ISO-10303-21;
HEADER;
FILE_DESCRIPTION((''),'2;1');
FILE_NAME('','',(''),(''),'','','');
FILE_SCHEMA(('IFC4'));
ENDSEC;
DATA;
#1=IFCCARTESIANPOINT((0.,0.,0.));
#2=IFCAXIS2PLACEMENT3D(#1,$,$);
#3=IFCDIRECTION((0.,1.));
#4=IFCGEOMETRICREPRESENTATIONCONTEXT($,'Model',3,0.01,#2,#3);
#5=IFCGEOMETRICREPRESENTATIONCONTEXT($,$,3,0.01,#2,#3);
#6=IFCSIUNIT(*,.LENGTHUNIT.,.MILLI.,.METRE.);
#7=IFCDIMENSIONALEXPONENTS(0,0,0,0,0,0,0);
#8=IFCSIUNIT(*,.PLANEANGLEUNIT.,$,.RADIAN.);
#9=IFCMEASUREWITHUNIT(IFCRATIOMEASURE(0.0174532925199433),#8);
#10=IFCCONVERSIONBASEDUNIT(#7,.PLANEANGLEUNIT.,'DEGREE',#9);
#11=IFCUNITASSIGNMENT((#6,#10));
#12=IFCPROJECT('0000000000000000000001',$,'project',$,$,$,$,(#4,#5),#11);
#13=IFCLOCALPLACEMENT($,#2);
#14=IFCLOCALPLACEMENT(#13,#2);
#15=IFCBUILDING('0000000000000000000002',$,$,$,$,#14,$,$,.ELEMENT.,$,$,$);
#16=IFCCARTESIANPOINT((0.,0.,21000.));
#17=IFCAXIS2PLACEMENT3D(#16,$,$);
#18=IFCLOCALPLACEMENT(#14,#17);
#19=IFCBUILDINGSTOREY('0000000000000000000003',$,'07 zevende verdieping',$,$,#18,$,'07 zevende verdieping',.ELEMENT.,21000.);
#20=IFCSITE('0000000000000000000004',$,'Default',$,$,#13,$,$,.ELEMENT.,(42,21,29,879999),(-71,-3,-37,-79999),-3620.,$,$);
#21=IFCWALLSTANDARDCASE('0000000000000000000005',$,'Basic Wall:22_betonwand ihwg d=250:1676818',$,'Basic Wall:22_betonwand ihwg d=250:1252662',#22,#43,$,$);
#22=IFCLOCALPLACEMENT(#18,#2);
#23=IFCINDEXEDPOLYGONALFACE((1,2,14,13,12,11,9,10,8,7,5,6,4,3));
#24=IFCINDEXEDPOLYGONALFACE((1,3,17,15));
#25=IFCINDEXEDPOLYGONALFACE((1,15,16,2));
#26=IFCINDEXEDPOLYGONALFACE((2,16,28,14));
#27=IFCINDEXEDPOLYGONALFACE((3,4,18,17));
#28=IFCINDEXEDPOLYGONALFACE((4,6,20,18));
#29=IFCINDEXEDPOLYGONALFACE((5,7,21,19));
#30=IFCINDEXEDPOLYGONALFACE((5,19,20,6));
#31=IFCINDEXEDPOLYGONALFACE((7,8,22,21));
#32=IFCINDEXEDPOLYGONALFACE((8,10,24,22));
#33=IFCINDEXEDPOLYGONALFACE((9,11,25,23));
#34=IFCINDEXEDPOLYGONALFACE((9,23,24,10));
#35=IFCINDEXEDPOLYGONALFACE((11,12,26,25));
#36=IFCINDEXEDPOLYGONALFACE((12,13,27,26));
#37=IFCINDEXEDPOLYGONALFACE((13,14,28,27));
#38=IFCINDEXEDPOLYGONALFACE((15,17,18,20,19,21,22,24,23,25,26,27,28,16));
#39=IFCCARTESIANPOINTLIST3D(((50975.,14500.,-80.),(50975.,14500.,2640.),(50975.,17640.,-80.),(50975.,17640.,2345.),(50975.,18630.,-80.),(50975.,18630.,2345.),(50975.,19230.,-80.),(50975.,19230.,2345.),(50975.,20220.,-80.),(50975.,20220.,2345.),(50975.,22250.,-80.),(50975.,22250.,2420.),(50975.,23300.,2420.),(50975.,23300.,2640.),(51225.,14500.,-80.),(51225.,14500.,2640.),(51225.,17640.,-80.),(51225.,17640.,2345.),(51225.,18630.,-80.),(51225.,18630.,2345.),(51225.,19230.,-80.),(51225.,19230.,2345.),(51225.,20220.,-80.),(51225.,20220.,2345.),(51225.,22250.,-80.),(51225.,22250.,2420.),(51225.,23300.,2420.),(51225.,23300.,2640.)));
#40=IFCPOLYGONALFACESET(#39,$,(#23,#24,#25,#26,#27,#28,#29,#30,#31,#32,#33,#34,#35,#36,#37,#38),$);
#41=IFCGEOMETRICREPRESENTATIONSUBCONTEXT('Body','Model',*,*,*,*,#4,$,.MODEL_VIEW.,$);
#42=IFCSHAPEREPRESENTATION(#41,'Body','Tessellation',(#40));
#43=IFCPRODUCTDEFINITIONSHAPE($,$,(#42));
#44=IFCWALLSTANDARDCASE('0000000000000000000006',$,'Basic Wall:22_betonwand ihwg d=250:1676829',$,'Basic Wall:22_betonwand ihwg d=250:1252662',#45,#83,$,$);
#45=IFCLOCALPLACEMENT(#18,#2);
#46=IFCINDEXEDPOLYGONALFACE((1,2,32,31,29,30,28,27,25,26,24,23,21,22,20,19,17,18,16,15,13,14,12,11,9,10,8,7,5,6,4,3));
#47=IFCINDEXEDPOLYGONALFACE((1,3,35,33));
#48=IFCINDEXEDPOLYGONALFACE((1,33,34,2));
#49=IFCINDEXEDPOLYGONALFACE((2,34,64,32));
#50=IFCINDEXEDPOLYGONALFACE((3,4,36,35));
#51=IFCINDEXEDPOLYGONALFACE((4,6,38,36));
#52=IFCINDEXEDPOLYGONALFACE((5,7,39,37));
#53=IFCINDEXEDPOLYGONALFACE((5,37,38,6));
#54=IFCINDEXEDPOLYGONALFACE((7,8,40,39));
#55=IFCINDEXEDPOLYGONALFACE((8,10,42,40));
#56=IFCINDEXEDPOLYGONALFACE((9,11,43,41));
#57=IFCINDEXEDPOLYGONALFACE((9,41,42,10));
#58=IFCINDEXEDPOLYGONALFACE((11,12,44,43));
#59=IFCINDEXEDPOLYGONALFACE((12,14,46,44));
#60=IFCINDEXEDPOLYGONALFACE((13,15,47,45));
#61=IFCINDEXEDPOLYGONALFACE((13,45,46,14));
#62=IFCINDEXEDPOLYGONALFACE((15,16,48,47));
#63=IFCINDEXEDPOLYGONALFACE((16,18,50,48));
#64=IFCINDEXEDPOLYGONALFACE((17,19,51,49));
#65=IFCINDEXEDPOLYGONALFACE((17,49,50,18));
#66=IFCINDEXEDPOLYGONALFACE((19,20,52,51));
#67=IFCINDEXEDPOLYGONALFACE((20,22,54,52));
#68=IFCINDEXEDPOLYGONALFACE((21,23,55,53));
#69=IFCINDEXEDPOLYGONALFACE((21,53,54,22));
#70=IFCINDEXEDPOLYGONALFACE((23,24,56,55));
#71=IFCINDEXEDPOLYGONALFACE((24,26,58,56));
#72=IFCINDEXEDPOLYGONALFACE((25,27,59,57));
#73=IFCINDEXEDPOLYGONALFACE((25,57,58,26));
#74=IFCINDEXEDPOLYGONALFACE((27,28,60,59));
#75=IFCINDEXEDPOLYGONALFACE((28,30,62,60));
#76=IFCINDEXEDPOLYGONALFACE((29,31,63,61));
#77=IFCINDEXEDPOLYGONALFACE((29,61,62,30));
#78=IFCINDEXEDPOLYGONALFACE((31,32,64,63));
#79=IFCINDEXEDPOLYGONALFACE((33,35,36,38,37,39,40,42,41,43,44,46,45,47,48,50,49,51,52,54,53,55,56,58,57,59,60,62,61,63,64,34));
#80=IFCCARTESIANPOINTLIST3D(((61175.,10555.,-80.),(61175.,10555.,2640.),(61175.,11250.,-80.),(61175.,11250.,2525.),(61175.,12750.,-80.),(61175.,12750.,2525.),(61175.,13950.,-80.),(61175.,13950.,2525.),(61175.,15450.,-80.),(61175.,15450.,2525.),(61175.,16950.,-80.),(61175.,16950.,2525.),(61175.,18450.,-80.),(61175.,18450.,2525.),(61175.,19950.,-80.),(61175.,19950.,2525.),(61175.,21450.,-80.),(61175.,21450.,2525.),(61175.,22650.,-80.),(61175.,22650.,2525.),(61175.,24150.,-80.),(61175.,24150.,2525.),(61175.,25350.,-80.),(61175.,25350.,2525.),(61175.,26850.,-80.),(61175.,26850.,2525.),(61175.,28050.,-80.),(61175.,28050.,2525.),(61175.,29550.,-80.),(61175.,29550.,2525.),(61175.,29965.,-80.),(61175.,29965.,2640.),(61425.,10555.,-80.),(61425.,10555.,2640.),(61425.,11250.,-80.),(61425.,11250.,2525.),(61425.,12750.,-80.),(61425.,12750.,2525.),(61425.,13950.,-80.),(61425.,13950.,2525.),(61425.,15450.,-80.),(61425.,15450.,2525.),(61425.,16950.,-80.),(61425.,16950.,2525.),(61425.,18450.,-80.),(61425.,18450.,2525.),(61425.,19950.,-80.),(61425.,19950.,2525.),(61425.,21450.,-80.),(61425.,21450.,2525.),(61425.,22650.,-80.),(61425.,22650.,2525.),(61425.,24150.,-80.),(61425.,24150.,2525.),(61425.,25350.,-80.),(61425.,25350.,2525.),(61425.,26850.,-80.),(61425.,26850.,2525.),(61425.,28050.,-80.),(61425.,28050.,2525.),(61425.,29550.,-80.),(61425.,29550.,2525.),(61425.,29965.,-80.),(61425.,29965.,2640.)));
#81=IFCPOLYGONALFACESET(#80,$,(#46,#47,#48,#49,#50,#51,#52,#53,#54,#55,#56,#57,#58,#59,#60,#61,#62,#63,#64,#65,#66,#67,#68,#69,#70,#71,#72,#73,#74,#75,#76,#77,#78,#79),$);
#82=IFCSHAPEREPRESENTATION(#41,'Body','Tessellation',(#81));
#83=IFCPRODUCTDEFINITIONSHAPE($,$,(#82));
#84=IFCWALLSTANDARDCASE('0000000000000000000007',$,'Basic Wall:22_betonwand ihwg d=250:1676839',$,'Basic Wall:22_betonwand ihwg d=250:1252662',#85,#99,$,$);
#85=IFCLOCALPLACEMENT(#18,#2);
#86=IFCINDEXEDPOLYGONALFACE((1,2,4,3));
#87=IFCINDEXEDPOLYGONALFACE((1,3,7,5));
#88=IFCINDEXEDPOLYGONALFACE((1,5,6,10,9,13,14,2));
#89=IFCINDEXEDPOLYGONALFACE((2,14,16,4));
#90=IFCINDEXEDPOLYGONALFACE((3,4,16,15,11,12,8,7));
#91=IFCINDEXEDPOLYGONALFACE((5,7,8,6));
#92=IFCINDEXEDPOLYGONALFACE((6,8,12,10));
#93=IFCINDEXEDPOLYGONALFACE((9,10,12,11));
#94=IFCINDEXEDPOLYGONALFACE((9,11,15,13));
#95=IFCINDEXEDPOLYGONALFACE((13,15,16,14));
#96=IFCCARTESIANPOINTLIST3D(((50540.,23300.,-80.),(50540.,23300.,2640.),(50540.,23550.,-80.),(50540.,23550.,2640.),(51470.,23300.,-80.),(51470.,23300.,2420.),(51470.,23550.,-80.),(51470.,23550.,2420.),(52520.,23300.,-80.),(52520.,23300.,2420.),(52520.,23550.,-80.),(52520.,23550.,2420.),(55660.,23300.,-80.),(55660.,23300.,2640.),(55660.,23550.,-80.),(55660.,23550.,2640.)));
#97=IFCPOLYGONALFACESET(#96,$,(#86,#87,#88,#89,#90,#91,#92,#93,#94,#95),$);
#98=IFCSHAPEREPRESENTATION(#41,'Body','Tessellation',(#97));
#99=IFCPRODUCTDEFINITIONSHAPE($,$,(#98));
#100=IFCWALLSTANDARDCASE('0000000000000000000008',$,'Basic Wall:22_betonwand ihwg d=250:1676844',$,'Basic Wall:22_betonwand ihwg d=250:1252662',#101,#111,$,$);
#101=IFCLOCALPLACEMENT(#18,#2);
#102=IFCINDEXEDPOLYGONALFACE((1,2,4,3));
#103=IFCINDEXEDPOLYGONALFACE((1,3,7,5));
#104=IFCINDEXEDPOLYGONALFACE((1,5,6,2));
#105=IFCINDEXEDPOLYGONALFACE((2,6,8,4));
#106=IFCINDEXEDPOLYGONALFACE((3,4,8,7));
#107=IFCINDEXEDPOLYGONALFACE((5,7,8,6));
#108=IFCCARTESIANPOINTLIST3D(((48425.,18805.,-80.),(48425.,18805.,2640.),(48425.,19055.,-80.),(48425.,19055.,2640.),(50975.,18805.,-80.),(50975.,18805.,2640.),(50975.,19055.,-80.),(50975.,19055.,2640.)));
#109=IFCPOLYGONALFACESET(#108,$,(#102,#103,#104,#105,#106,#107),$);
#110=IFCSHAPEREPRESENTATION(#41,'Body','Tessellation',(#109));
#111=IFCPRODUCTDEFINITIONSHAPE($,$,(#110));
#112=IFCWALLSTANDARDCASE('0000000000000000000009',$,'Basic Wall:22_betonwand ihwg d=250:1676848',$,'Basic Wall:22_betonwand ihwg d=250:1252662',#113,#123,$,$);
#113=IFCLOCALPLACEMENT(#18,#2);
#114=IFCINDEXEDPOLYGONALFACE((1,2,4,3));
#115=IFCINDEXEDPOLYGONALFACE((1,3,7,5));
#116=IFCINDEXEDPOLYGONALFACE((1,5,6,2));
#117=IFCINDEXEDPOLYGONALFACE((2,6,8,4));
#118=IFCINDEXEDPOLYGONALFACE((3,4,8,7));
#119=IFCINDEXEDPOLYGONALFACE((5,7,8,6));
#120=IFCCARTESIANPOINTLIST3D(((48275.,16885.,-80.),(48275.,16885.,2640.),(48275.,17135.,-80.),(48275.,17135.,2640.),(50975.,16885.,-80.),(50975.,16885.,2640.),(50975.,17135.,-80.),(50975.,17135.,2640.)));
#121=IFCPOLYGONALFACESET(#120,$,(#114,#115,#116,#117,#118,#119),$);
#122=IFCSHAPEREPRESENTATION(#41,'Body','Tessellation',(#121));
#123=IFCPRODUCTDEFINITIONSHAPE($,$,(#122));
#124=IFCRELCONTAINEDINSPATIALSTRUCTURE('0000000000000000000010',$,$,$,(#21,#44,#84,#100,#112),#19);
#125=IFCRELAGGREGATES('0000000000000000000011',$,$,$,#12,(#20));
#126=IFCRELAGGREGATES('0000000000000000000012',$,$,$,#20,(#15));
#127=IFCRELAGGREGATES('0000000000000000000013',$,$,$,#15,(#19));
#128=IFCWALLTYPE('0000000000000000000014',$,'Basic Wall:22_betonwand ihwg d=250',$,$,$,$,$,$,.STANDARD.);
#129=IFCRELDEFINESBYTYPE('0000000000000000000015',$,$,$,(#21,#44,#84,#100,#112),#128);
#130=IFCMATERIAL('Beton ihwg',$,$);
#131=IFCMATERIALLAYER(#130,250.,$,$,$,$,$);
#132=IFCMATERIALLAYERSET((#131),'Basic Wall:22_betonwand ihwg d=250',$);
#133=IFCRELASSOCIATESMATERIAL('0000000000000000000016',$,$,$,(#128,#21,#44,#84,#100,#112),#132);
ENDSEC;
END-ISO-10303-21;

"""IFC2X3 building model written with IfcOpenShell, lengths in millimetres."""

from ifc_helpers import new_model, entity, si_unit, converted_unit, direction, frame, frame_2d, origin, place, context, subcontext, project, spatial, rectangle, extrude, material, layer, layer_set, layer_usage, type_object, element, save


model = new_model("IFC2X3")

# Units and contexts
model_context = context("Model", 3, precision=0.01, world=origin(), true_north=direction((0.0, 1.0)))
context_of_model = context(None, 3, precision=0.01, world=origin(), true_north=direction((0.0, 1.0)))
body_context = subcontext(model_context, "Body", "Model", "MODEL_VIEW")
ifc_project = project(units=[si_unit("LENGTHUNIT", "METRE", prefix="MILLI"), converted_unit("PLANEANGLEUNIT", "DEGREE", entity("IfcRatioMeasure", 0.0174532925199433), si_unit("PLANEANGLEUNIT", "RADIAN"), dimensions=[0, 0, 0, 0, 0, 0, 0])], contexts=[model_context, context_of_model])

# Site, building, storey
site_placement = place(None, origin())
site = spatial("IfcSite", under=ifc_project, at=site_placement, Name="Default", CompositionType="ELEMENT", RefLatitude=(42, 21, 29, 879999), RefLongitude=(-71, -3, -37, -79999), RefElevation=-3620.0)
building_placement = place(site_placement, origin())
building = spatial("IfcBuilding", under=site, at=building_placement, CompositionType="ELEMENT")
storey_placement = place(building_placement, frame((0.0, 0.0, 21000.0)))
storey = spatial("IfcBuildingStorey", under=building, at=storey_placement, Name="07 zevende verdieping", LongName="07 zevende verdieping", CompositionType="ELEMENT", Elevation=21000.0)

# Walls, openings
ifc_material_1 = material(Name="Beton ihwg")
ifc_layer_1 = layer(ifc_material_1, 250.0)
ifc_layer_set_1 = layer_set([ifc_layer_1], Name="Basic Wall:22_betonwand ihwg d=250")
ifc_layer_usage_1 = layer_usage(ifc_layer_set_1, "AXIS2", "NEGATIVE", 125.0)
wall_type_1 = type_object("IfcWallType", Name="Basic Wall:22_betonwand ihwg d=250", PredefinedType="STANDARD", material=ifc_layer_set_1)
wall_1_placement = place(storey_placement, frame((51100.0, 23300.0, -80.0), z_axis=(0.0, 0.0, 1.0), x_axis=(0.0, -1.0, 0.0)))
wall_1 = element("IfcWallStandardCase", 1, at=wall_1_placement, inside=storey, type_object=wall_type_1, material=ifc_layer_usage_1, Name="Basic Wall:22_betonwand ihwg d=250:1676818", ObjectType="Basic Wall:22_betonwand ihwg d=250:1252662", context=body_context, shape_type="SweptSolid", body=[
    extrude(rectangle(XDim=8800.0, YDim=250.0, at=frame_2d((4400.0, 0.0), x_axis=(-1.0, 0.0))), origin(), (0.0, 0.0, 1.0), 2720.0),
])
opening_1_placement = place(wall_1_placement, frame((23300.0, -51100.0, 80.0), z_axis=(0.0, 0.0, 1.0), x_axis=(0.0, 1.0, 0.0)))
element("IfcOpeningElement", 2, at=opening_1_placement, cuts=wall_1, ObjectType="Opening", context=body_context, shape_type="SweptSolid", body=[
    extrude(rectangle(XDim=2425.0, YDim=990.0, at=frame_2d((0.0, 0.0), x_axis=(1.0, 0.0))), frame((50700.0, 19725.0, 1132.5), z_axis=(1.0, 0.0, 0.0), x_axis=(0.0, 0.0, -1.0)), (0.0, 0.0, 1.0), 800.0),
])
opening_2_placement = place(wall_1_placement, frame((23300.0, -51100.0, 80.0), z_axis=(0.0, 0.0, 1.0), x_axis=(0.0, 1.0, 0.0)))
element("IfcOpeningElement", 3, at=opening_2_placement, cuts=wall_1, ObjectType="Opening", context=body_context, shape_type="SweptSolid", body=[
    extrude(rectangle(XDim=2425.0, YDim=990.0, at=frame_2d((0.0, 0.0), x_axis=(1.0, 0.0))), frame((50700.0, 18135.0, 1132.5), z_axis=(1.0, 0.0, 0.0), x_axis=(0.0, 0.0, -1.0)), (0.0, 0.0, 1.0), 800.0),
])
opening_3_placement = place(wall_1_placement, frame((23300.0, -51100.0, 80.0), z_axis=(0.0, 0.0, 1.0), x_axis=(0.0, 1.0, 0.0)))
element("IfcOpeningElement", 4, at=opening_3_placement, cuts=wall_1, ObjectType="Opening", context=body_context, shape_type="SweptSolid", body=[
    extrude(rectangle(XDim=2500.0, YDim=1050.0, at=frame_2d((0.0, 0.0), x_axis=(1.0, 0.0))), frame((50700.0, 22775.0, 1170.0), z_axis=(1.0, 0.0, 0.0), x_axis=(0.0, 0.0, -1.0)), (0.0, 0.0, 1.0), 800.0),
])
ifc_layer_usage_2 = layer_usage(ifc_layer_set_1, "AXIS2", "POSITIVE", -125.0)
wall_2_placement = place(storey_placement, frame((61300.0, 29965.0, -80.0), z_axis=(0.0, 0.0, 1.0), x_axis=(0.0, -1.0, 0.0)))
wall_2 = element("IfcWallStandardCase", 5, at=wall_2_placement, inside=storey, type_object=wall_type_1, material=ifc_layer_usage_2, Name="Basic Wall:22_betonwand ihwg d=250:1676829", ObjectType="Basic Wall:22_betonwand ihwg d=250:1252662", context=body_context, shape_type="SweptSolid", body=[
    extrude(rectangle(XDim=19410.0, YDim=250.0, at=frame_2d((9705.0, 0.0), x_axis=(-1.0, 0.0))), origin(), (0.0, 0.0, 1.0), 2720.0),
])
opening_4_placement = place(wall_2_placement, frame((29965.0, -61300.0, 80.0), z_axis=(0.0, 0.0, 1.0), x_axis=(0.0, 1.0, 0.0)))
element("IfcOpeningElement", 6, at=opening_4_placement, cuts=wall_2, ObjectType="Opening", context=body_context, shape_type="SweptSolid", body=[
    extrude(rectangle(XDim=2605.0, YDim=1500.0, at=frame_2d((0.0, 0.0), x_axis=(1.0, 0.0))), frame((59901.0, 28800.0, 1222.5), z_axis=(1.0, 0.0, 0.0), x_axis=(0.0, 0.0, -1.0)), (0.0, 0.0, 1.0), 3048.0),
])
opening_5_placement = place(wall_2_placement, frame((29965.0, -61300.0, 80.0), z_axis=(0.0, 0.0, 1.0), x_axis=(0.0, 1.0, 0.0)))
element("IfcOpeningElement", 7, at=opening_5_placement, cuts=wall_2, ObjectType="Opening", context=body_context, shape_type="SweptSolid", body=[
    extrude(rectangle(XDim=2605.0, YDim=1500.0, at=frame_2d((0.0, 0.0), x_axis=(1.0, 0.0))), frame((59901.0, 26100.0, 1222.5), z_axis=(1.0, 0.0, 0.0), x_axis=(0.0, 0.0, -1.0)), (0.0, 0.0, 1.0), 3048.0),
])
opening_6_placement = place(wall_2_placement, frame((29965.0, -61300.0, 80.0), z_axis=(0.0, 0.0, 1.0), x_axis=(0.0, 1.0, 0.0)))
element("IfcOpeningElement", 8, at=opening_6_placement, cuts=wall_2, ObjectType="Opening", context=body_context, shape_type="SweptSolid", body=[
    extrude(rectangle(XDim=2605.0, YDim=1500.0, at=frame_2d((0.0, 0.0), x_axis=(1.0, 0.0))), frame((59901.0, 23400.0, 1222.5), z_axis=(1.0, 0.0, 0.0), x_axis=(0.0, 0.0, -1.0)), (0.0, 0.0, 1.0), 3048.0),
])
opening_7_placement = place(wall_2_placement, frame((29965.0, -61300.0, 80.0), z_axis=(0.0, 0.0, 1.0), x_axis=(0.0, 1.0, 0.0)))
element("IfcOpeningElement", 9, at=opening_7_placement, cuts=wall_2, ObjectType="Opening", context=body_context, shape_type="SweptSolid", body=[
    extrude(rectangle(XDim=2605.0, YDim=1500.0, at=frame_2d((0.0, 0.0), x_axis=(1.0, 0.0))), frame((59901.0, 17700.0, 1222.5), z_axis=(1.0, 0.0, 0.0), x_axis=(0.0, 0.0, -1.0)), (0.0, 0.0, 1.0), 3048.0),
])
opening_8_placement = place(wall_2_placement, frame((29965.0, -61300.0, 80.0), z_axis=(0.0, 0.0, 1.0), x_axis=(0.0, 1.0, 0.0)))
element("IfcOpeningElement", 10, at=opening_8_placement, cuts=wall_2, ObjectType="Opening", context=body_context, shape_type="SweptSolid", body=[
    extrude(rectangle(XDim=2605.0, YDim=1500.0, at=frame_2d((0.0, 0.0), x_axis=(1.0, 0.0))), frame((59901.0, 14700.0, 1222.5), z_axis=(1.0, 0.0, 0.0), x_axis=(0.0, 0.0, -1.0)), (0.0, 0.0, 1.0), 3048.0),
])
opening_9_placement = place(wall_2_placement, frame((29965.0, -61300.0, 80.0), z_axis=(0.0, 0.0, 1.0), x_axis=(0.0, 1.0, 0.0)))
element("IfcOpeningElement", 11, at=opening_9_placement, cuts=wall_2, ObjectType="Opening", context=body_context, shape_type="SweptSolid", body=[
    extrude(rectangle(XDim=2605.0, YDim=1500.0, at=frame_2d((0.0, 0.0), x_axis=(1.0, 0.0))), frame((59901.0, 20700.0, 1222.5), z_axis=(1.0, 0.0, 0.0), x_axis=(0.0, 0.0, -1.0)), (0.0, 0.0, 1.0), 3048.0),
])
opening_10_placement = place(wall_2_placement, frame((29965.0, -61300.0, 80.0), z_axis=(0.0, 0.0, 1.0), x_axis=(0.0, 1.0, 0.0)))
element("IfcOpeningElement", 12, at=opening_10_placement, cuts=wall_2, ObjectType="Opening", context=body_context, shape_type="SweptSolid", body=[
    extrude(rectangle(XDim=2605.0, YDim=1500.0, at=frame_2d((0.0, 0.0), x_axis=(1.0, 0.0))), frame((59901.0, 12000.0, 1222.5), z_axis=(1.0, 0.0, 0.0), x_axis=(0.0, 0.0, -1.0)), (0.0, 0.0, 1.0), 3048.0),
])
ifc_layer_usage_3 = layer_usage(ifc_layer_set_1, "AXIS2", "POSITIVE", -125.0)
wall_3_placement = place(storey_placement, frame((55660.0, 23425.0, -80.0), z_axis=(0.0, 0.0, 1.0), x_axis=(-1.0, 0.0, 0.0)))
wall_3 = element("IfcWallStandardCase", 13, at=wall_3_placement, inside=storey, type_object=wall_type_1, material=ifc_layer_usage_3, Name="Basic Wall:22_betonwand ihwg d=250:1676839", ObjectType="Basic Wall:22_betonwand ihwg d=250:1252662", context=body_context, shape_type="SweptSolid", body=[
    extrude(rectangle(XDim=5120.0, YDim=250.0, at=frame_2d((2560.0, 0.0), x_axis=(-1.0, 0.0))), origin(), (0.0, 0.0, 1.0), 2720.0),
])
opening_11_placement = place(wall_3_placement, origin())
element("IfcOpeningElement", 14, at=opening_11_placement, cuts=wall_3, ObjectType="Opening", context=body_context, shape_type="SweptSolid", body=[
    extrude(rectangle(XDim=2500.0, YDim=800.0, at=frame_2d((0.0, 0.0), x_axis=(0.0, 1.0))), frame((4560.0, 125.0, 1250.0), z_axis=(0.0, 1.0, 0.0), x_axis=(1.0, 0.0, 0.0)), (0.0, 0.0, 1.0), 1050.0),
])
opening_12_placement = place(wall_3_placement, origin())
element("IfcOpeningElement", 15, at=opening_12_placement, cuts=wall_3, ObjectType="Opening", context=body_context, shape_type="SweptSolid", body=[
    extrude(rectangle(XDim=2500.0, YDim=800.0, at=frame_2d((0.0, 0.0), x_axis=(0.0, 1.0))), frame((2735.0, 125.0, 1250.0), z_axis=(0.0, 1.0, 0.0), x_axis=(1.0, 0.0, 0.0)), (0.0, 0.0, 1.0), 1034.0),
])
opening_13_placement = place(wall_3_placement, frame((55660.0, 23425.0, 80.0), z_axis=(0.0, 0.0, 1.0), x_axis=(-1.0, 0.0, 0.0)))
element("IfcOpeningElement", 16, at=opening_13_placement, cuts=wall_3, ObjectType="Opening", context=body_context, shape_type="SweptSolid", body=[
    extrude(rectangle(XDim=2500.0, YDim=1050.0, at=frame_2d((0.0, 0.0), x_axis=(0.0, 1.0))), frame((51995.0, 23825.0, 1170.0), z_axis=(0.0, -1.0, 0.0), x_axis=(-1.0, 0.0, 0.0)), (0.0, 0.0, 1.0), 800.0),
])

# Walls
ifc_layer_usage_4 = layer_usage(ifc_layer_set_1, "AXIS2", "POSITIVE", -125.0)
wall_4_placement = place(storey_placement, frame((50975.0, 18930.0, -80.0), z_axis=(0.0, 0.0, 1.0), x_axis=(-1.0, 0.0, 0.0)))
element("IfcWallStandardCase", 17, at=wall_4_placement, inside=storey, type_object=wall_type_1, material=ifc_layer_usage_4, Name="Basic Wall:22_betonwand ihwg d=250:1676844", ObjectType="Basic Wall:22_betonwand ihwg d=250:1252662", context=body_context, shape_type="SweptSolid", body=[
    extrude(rectangle(XDim=2550.0, YDim=250.0, at=frame_2d((1275.0, 0.0), x_axis=(-1.0, 0.0))), origin(), (0.0, 0.0, 1.0), 2720.0),
])
ifc_layer_usage_5 = layer_usage(ifc_layer_set_1, "AXIS2", "POSITIVE", -125.0)
wall_5_placement = place(storey_placement, frame((50975.0, 17010.0, -80.0), z_axis=(0.0, 0.0, 1.0), x_axis=(-1.0, 0.0, 0.0)))
element("IfcWallStandardCase", 18, at=wall_5_placement, inside=storey, type_object=wall_type_1, material=ifc_layer_usage_5, Name="Basic Wall:22_betonwand ihwg d=250:1676848", ObjectType="Basic Wall:22_betonwand ihwg d=250:1252662", context=body_context, shape_type="SweptSolid", body=[
    extrude(rectangle(XDim=2700.0, YDim=250.0, at=frame_2d((1350.0, 0.0), x_axis=(-1.0, 0.0))), origin(), (0.0, 0.0, 1.0), 2720.0),
])

save(model, "model.ifc")
